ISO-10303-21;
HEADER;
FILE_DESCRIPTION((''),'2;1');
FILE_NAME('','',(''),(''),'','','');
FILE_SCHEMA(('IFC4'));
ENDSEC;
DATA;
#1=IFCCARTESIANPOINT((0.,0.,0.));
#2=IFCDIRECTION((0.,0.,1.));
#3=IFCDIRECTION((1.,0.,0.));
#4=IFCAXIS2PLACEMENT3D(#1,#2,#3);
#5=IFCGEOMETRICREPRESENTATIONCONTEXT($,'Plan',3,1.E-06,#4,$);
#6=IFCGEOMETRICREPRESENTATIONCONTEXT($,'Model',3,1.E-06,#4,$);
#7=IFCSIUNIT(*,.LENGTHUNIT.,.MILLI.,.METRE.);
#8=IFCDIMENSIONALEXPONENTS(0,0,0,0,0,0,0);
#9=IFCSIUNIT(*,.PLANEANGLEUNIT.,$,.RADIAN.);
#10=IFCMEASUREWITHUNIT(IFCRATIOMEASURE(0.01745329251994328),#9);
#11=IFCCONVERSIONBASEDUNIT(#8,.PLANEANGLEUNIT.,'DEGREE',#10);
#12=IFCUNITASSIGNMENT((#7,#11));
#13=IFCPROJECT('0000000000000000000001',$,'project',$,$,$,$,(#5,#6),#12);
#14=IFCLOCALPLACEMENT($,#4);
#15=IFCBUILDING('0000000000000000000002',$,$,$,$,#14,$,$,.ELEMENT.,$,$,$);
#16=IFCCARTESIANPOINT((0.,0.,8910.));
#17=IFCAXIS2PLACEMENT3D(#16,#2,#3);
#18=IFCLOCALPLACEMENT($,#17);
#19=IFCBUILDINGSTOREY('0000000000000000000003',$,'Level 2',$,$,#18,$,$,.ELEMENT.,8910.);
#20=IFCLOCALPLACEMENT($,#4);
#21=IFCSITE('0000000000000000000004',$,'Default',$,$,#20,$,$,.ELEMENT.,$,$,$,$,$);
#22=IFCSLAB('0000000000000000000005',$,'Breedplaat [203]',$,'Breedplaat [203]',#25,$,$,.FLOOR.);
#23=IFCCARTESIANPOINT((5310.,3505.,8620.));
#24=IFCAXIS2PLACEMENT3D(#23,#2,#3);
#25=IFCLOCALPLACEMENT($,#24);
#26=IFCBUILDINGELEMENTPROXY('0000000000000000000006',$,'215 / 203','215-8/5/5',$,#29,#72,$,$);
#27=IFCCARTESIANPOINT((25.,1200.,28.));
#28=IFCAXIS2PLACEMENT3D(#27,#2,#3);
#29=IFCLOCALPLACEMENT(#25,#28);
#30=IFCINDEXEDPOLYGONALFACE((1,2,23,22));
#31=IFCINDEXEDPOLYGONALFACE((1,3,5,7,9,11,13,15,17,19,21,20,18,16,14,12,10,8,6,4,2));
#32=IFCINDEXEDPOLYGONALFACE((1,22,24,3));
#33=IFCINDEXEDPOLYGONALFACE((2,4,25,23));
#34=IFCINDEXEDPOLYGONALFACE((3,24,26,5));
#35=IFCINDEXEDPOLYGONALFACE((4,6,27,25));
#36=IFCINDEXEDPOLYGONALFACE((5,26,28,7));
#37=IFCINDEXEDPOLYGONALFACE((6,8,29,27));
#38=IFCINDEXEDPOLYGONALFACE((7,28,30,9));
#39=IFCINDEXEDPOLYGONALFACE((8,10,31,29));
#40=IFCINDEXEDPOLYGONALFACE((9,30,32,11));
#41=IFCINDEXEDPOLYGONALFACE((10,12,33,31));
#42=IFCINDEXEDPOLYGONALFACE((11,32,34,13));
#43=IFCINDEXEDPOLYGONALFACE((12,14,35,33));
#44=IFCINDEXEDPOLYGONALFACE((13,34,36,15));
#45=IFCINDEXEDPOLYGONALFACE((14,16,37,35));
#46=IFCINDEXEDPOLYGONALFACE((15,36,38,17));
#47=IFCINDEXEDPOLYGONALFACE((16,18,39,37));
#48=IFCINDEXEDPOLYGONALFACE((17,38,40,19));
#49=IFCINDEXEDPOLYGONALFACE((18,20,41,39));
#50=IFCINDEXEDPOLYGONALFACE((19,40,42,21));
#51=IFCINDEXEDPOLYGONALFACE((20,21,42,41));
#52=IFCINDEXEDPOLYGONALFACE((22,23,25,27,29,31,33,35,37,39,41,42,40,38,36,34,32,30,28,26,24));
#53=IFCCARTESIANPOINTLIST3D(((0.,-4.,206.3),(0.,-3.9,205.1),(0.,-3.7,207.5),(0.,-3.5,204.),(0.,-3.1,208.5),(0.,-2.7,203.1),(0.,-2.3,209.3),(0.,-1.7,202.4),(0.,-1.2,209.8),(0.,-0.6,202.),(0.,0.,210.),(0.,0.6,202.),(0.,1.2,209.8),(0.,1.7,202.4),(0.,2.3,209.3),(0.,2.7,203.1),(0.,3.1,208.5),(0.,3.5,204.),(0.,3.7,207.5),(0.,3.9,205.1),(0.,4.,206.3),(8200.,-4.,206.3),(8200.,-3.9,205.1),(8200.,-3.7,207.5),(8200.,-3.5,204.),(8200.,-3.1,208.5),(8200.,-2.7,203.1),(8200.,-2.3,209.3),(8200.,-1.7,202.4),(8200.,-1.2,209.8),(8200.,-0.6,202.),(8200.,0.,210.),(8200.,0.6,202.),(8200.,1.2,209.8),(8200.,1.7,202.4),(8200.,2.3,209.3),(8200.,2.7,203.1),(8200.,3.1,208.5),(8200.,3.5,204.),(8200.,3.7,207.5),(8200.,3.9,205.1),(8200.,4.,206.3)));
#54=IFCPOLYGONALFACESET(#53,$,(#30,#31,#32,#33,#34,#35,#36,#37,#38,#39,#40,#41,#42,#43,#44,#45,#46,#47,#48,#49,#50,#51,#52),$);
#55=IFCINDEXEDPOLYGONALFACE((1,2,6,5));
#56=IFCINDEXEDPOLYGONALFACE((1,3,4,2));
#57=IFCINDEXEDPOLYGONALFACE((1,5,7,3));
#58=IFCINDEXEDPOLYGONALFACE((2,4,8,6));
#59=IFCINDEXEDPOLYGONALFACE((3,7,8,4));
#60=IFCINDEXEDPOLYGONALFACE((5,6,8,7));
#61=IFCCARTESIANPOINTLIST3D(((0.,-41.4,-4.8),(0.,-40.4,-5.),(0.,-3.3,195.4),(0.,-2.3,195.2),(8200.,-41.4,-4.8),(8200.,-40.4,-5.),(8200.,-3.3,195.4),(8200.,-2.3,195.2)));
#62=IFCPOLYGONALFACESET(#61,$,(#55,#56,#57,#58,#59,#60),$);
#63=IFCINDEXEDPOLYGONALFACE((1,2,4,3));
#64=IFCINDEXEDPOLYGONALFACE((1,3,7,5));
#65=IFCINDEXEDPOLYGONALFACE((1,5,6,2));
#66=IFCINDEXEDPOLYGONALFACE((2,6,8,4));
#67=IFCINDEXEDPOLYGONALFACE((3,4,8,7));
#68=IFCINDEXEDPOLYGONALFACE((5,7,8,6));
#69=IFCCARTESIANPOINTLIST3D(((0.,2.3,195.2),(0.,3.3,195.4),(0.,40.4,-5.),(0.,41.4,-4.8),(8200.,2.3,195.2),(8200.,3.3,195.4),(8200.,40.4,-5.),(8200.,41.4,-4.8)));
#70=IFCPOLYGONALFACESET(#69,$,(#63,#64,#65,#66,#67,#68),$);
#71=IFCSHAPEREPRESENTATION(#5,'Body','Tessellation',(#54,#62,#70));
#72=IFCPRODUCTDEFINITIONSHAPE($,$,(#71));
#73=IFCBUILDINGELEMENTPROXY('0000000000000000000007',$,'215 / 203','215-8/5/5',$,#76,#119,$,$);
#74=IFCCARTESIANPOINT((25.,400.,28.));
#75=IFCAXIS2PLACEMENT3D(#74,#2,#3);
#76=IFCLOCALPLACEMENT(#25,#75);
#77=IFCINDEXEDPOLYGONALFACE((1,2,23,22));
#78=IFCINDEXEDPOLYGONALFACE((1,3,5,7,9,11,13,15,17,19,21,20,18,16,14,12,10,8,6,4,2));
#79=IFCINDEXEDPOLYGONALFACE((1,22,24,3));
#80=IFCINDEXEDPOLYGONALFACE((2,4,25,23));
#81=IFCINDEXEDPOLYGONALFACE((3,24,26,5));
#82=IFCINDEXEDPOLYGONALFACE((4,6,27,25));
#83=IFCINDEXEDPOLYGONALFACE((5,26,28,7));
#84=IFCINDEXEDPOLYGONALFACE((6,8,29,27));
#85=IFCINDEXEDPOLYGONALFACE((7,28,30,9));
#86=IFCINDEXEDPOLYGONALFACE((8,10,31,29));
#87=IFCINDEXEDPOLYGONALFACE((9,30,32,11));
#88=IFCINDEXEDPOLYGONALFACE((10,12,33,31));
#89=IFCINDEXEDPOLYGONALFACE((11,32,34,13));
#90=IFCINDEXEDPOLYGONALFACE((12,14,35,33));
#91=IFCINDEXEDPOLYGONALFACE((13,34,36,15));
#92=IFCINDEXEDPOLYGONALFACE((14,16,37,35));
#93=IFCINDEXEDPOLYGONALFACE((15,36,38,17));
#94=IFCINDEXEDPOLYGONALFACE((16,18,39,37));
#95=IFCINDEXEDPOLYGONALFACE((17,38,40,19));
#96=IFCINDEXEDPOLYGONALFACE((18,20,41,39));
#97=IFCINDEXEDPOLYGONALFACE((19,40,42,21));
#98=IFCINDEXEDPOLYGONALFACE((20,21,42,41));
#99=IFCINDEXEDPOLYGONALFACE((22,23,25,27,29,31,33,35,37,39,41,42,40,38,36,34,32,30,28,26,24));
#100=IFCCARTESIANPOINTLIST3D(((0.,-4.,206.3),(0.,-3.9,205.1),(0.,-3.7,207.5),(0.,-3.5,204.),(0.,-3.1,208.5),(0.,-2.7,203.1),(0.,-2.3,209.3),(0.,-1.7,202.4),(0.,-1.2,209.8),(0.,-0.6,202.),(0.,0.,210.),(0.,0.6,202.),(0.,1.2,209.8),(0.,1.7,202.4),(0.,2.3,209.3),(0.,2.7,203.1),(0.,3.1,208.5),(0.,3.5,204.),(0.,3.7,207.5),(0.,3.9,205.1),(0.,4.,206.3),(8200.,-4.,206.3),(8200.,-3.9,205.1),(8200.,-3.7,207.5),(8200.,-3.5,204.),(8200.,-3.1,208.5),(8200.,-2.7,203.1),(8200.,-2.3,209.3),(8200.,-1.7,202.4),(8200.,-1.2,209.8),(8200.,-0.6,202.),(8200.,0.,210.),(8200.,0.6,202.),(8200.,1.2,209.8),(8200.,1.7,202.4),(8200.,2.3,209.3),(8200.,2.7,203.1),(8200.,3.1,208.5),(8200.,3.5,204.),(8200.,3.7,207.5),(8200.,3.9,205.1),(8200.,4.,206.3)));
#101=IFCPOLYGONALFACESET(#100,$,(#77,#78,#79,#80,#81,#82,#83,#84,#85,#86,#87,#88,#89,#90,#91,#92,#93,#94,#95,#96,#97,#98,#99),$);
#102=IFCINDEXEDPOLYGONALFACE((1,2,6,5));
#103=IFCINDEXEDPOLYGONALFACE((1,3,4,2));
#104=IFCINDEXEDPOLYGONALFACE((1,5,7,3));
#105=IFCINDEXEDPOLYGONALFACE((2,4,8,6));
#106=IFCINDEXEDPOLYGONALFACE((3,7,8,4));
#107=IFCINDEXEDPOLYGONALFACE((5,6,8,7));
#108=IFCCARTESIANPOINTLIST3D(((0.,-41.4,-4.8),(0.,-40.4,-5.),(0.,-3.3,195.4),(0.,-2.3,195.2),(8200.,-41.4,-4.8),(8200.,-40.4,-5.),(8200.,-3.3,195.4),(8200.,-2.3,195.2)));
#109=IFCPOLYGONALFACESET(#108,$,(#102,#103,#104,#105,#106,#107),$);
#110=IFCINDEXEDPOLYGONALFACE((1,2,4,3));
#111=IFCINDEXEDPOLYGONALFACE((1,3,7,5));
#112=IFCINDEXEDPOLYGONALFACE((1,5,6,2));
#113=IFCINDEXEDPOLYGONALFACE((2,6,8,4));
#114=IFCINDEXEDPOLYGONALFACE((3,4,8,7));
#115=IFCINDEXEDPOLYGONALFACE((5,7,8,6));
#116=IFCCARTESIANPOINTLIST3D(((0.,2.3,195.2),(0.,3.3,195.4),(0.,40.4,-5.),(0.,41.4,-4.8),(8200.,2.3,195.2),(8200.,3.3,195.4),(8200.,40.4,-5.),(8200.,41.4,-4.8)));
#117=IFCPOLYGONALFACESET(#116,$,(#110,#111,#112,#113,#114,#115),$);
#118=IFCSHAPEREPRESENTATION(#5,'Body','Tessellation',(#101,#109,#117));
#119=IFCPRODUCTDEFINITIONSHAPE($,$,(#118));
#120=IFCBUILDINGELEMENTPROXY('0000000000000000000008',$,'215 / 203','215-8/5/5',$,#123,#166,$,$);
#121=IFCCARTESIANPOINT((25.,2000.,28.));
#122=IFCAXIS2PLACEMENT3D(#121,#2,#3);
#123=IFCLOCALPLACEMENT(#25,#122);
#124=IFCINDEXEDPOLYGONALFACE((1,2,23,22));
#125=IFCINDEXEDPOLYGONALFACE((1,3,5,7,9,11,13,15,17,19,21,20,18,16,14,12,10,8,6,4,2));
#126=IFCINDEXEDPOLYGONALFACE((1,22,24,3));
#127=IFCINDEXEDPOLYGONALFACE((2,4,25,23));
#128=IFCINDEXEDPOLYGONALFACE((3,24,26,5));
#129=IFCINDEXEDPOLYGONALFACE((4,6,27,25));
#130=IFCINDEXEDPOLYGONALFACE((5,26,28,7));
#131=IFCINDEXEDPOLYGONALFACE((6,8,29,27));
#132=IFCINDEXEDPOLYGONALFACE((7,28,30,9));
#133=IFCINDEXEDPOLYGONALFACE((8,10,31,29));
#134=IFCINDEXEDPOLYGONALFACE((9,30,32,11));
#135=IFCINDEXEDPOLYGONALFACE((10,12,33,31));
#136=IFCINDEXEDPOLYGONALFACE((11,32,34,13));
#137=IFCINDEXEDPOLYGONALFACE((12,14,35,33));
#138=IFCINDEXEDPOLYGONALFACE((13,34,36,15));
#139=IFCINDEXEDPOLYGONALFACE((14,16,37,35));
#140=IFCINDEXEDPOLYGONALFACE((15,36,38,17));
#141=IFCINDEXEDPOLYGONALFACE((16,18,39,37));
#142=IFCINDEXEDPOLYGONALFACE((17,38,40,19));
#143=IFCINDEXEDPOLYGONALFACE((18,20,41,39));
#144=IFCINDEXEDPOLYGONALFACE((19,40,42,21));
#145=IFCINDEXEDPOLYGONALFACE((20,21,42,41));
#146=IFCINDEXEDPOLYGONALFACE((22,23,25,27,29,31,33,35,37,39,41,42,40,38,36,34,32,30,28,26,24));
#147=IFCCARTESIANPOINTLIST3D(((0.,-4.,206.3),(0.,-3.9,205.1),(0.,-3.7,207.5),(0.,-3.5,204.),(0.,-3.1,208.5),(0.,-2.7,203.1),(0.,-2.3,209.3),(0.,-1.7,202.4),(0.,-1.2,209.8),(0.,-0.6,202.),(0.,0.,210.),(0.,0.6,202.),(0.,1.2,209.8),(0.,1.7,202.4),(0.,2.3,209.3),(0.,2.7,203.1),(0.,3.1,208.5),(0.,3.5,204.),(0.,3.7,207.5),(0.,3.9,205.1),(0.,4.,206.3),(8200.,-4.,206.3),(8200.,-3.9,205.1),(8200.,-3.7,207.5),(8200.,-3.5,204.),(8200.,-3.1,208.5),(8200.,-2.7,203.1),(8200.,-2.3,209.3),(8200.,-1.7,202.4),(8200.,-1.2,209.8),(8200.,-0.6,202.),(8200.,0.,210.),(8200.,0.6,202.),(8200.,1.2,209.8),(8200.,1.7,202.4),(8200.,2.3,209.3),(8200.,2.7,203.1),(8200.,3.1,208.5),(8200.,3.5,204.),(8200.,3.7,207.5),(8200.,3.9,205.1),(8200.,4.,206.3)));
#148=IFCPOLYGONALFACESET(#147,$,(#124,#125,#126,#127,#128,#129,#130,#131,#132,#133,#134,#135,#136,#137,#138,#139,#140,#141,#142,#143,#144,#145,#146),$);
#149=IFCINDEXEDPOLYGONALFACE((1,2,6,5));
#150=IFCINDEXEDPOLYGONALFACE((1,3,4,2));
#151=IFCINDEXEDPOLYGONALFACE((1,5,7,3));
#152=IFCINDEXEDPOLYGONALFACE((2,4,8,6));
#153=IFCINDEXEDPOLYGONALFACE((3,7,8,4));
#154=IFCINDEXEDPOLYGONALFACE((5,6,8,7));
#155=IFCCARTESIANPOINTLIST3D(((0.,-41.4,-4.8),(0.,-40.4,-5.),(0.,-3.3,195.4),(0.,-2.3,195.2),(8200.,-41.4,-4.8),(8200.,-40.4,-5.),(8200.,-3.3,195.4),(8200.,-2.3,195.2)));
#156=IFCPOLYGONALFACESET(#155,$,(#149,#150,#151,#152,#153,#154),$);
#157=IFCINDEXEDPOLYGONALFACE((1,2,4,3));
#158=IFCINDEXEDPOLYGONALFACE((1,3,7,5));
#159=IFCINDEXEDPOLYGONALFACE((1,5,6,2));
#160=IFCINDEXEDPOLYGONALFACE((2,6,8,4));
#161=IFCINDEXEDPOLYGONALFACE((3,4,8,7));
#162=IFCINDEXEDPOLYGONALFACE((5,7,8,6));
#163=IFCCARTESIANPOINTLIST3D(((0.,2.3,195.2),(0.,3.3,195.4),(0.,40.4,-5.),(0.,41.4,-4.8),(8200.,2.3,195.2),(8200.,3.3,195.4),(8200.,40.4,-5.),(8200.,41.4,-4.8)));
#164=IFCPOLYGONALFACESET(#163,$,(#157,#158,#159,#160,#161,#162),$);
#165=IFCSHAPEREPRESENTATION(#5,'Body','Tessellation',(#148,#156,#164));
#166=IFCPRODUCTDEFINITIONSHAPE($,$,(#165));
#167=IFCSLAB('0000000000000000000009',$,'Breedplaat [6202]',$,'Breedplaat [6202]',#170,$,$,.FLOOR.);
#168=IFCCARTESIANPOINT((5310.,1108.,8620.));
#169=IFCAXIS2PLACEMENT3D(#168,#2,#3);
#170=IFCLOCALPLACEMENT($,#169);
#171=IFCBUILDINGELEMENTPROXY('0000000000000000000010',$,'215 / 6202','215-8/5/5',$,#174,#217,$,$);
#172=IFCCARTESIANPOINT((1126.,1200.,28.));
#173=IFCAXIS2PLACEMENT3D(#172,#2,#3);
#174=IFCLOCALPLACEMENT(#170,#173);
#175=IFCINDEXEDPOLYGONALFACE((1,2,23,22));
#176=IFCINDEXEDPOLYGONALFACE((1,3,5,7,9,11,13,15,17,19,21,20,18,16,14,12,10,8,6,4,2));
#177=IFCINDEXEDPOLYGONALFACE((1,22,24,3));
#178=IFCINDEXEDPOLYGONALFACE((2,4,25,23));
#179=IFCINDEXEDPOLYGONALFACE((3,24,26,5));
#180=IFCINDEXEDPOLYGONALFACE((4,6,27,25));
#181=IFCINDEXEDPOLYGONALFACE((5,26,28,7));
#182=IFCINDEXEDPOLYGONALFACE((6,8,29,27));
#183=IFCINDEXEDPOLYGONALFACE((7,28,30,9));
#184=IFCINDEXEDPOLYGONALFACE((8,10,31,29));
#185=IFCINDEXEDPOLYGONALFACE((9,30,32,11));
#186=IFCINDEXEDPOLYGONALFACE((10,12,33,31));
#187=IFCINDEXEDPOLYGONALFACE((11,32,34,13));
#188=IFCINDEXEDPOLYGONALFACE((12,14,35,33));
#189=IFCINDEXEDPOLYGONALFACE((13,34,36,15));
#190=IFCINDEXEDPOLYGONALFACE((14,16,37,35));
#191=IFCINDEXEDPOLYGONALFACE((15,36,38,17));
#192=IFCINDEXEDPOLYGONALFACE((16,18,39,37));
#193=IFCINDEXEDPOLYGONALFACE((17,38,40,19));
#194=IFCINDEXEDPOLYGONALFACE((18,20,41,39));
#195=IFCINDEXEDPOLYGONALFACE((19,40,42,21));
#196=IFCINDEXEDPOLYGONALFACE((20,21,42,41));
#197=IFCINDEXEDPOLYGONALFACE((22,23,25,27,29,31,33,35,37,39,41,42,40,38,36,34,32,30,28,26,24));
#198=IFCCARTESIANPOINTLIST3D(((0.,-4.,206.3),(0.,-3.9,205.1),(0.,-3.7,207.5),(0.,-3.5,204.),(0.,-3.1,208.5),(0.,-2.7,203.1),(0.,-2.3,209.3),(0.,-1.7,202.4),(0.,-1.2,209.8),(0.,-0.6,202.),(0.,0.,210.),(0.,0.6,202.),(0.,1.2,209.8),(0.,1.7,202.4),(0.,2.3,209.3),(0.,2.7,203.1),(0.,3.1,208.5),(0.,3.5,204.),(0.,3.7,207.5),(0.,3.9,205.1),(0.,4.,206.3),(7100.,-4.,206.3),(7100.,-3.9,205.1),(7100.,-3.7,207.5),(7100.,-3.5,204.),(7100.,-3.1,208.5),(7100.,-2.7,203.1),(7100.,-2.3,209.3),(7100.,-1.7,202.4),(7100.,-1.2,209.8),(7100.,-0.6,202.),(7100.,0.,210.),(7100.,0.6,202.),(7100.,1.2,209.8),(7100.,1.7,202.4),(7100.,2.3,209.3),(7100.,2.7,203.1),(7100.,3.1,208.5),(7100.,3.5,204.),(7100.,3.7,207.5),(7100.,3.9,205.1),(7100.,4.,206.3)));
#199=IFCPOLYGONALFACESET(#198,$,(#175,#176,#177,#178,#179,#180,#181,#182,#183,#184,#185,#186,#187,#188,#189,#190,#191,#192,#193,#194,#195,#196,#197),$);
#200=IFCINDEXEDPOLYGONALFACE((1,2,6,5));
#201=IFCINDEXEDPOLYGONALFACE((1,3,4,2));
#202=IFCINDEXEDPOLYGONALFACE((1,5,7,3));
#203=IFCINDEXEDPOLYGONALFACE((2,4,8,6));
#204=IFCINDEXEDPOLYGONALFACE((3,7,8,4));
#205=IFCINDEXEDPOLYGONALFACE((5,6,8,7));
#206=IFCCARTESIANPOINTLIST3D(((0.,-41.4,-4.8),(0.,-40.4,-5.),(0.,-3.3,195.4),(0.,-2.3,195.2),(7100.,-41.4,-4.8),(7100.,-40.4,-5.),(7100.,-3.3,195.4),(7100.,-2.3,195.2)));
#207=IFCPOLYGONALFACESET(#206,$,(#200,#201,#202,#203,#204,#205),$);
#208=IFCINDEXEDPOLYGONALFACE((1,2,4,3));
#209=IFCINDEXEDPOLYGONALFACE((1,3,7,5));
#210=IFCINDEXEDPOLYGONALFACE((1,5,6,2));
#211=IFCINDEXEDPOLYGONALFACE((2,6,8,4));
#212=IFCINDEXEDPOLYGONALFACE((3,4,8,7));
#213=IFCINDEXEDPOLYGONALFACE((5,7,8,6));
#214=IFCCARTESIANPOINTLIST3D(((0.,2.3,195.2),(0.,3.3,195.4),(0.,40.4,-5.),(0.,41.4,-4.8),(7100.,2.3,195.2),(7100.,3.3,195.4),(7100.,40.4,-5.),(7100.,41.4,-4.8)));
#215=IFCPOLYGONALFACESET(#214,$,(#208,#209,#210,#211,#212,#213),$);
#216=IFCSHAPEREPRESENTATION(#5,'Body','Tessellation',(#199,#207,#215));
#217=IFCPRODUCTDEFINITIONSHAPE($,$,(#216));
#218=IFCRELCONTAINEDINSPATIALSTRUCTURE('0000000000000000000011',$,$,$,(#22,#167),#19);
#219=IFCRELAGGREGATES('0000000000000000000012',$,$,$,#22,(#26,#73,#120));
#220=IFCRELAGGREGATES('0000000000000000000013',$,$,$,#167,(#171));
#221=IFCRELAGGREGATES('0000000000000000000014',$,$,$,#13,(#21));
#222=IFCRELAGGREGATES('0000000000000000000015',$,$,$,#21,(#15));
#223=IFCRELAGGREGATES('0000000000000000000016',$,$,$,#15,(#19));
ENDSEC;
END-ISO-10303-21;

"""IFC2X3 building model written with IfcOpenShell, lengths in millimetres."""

from ifc_helpers import new_model, entity, si_unit, converted_unit, frame, origin_with_axes, origin_2d_with_axis, place, context, project, spatial, rectangle, circle, extrude, element, aggregate, save


model = new_model("IFC2X3")

# Units and contexts
plan_context = context("Plan", 3, precision=1e-06, world=origin_with_axes())
model_context = context("Model", 3, precision=1e-06, world=origin_with_axes())
ifc_project = project(units=[si_unit("LENGTHUNIT", "METRE", prefix="MILLI"), converted_unit("PLANEANGLEUNIT", "DEGREE", entity("IfcRatioMeasure", 0.01745329251994328), si_unit("PLANEANGLEUNIT", "RADIAN"), dimensions=[0, 0, 0, 0, 0, 0, 0])], contexts=[plan_context, model_context])

# Site, building, storey
site_placement = place(None, origin_with_axes())
site = spatial("IfcSite", under=ifc_project, at=site_placement, Name="Default", CompositionType="ELEMENT")
building_placement = place(None, origin_with_axes())
building = spatial("IfcBuilding", under=site, at=building_placement, CompositionType="ELEMENT")
storey_placement = place(None, frame((0.0, 0.0, 8910.0), z_axis=(0.0, 0.0, 1.0), x_axis=(1.0, 0.0, 0.0)))
storey = spatial("IfcBuildingStorey", under=building, at=storey_placement, Name="Level 2", CompositionType="ELEMENT", Elevation=8910.0)

# Slab, building element proxies
slab_1_placement = place(None, frame((5310.0, 3505.0, 8620.0), z_axis=(0.0, 0.0, 1.0), x_axis=(1.0, 0.0, 0.0)))
slab_1 = element("IfcSlab", 1, at=slab_1_placement, inside=storey, Name="Breedplaat [203]", ObjectType="Breedplaat [203]", PredefinedType="FLOOR")
proxy_1_placement = place(slab_1_placement, frame((25.0, 1200.0, 28.0), z_axis=(0.0, 0.0, 1.0), x_axis=(1.0, 0.0, 0.0)))
proxy_1 = element("IfcBuildingElementProxy", 2, at=proxy_1_placement, Name="215 / 203", Description="215-8/5/5", context=plan_context, shape_type="SweptSolid", body=[
    extrude(circle(Radius=4.0, at=origin_2d_with_axis()), frame((0.0, 0.0, 206.0), z_axis=(1.0, 0.0, 0.0), x_axis=(0.0, 0.0, 1.0)), (0.0, 0.0, 1.0), 8200.0),
    extrude(rectangle(XDim=203.8, YDim=1.0, at=origin_2d_with_axis()), frame((0.0, -21.9, 95.2), z_axis=(1.0, 0.0, 0.0), x_axis=(0.0, 0.187112, 0.982339)), (0.0, 0.0, 1.0), 8200.0),
    extrude(rectangle(XDim=203.8, YDim=1.0, at=origin_2d_with_axis()), frame((0.0, 21.9, 95.2), z_axis=(1.0, 0.0, 0.0), x_axis=(0.0, -0.187112, 0.982339)), (0.0, 0.0, 1.0), 8200.0),
])
proxy_2_placement = place(slab_1_placement, frame((25.0, 400.0, 28.0), z_axis=(0.0, 0.0, 1.0), x_axis=(1.0, 0.0, 0.0)))
proxy_2 = element("IfcBuildingElementProxy", 3, at=proxy_2_placement, Name="215 / 203", Description="215-8/5/5", context=plan_context, shape_type="SweptSolid", body=[
    extrude(circle(Radius=4.0, at=origin_2d_with_axis()), frame((0.0, 0.0, 206.0), z_axis=(1.0, 0.0, 0.0), x_axis=(0.0, 0.0, 1.0)), (0.0, 0.0, 1.0), 8200.0),
    extrude(rectangle(XDim=203.8, YDim=1.0, at=origin_2d_with_axis()), frame((0.0, -21.9, 95.2), z_axis=(1.0, 0.0, 0.0), x_axis=(0.0, 0.187112, 0.982339)), (0.0, 0.0, 1.0), 8200.0),
    extrude(rectangle(XDim=203.8, YDim=1.0, at=origin_2d_with_axis()), frame((0.0, 21.9, 95.2), z_axis=(1.0, 0.0, 0.0), x_axis=(0.0, -0.187112, 0.982339)), (0.0, 0.0, 1.0), 8200.0),
])
proxy_3_placement = place(slab_1_placement, frame((25.0, 2000.0, 28.0), z_axis=(0.0, 0.0, 1.0), x_axis=(1.0, 0.0, 0.0)))
proxy_3 = element("IfcBuildingElementProxy", 4, at=proxy_3_placement, Name="215 / 203", Description="215-8/5/5", context=plan_context, shape_type="SweptSolid", body=[
    extrude(circle(Radius=4.0, at=origin_2d_with_axis()), frame((0.0, 0.0, 206.0), z_axis=(1.0, 0.0, 0.0), x_axis=(0.0, 0.0, 1.0)), (0.0, 0.0, 1.0), 8200.0),
    extrude(rectangle(XDim=203.8, YDim=1.0, at=origin_2d_with_axis()), frame((0.0, -21.9, 95.2), z_axis=(1.0, 0.0, 0.0), x_axis=(0.0, 0.187112, 0.982339)), (0.0, 0.0, 1.0), 8200.0),
    extrude(rectangle(XDim=203.8, YDim=1.0, at=origin_2d_with_axis()), frame((0.0, 21.9, 95.2), z_axis=(1.0, 0.0, 0.0), x_axis=(0.0, -0.187112, 0.982339)), (0.0, 0.0, 1.0), 8200.0),
])
aggregate(slab_1, [proxy_1, proxy_2, proxy_3])

# Slab, building element proxy
slab_2_placement = place(None, frame((5310.0, 1108.0, 8620.0), z_axis=(0.0, 0.0, 1.0), x_axis=(1.0, 0.0, 0.0)))
slab_2 = element("IfcSlab", 5, at=slab_2_placement, inside=storey, Name="Breedplaat [6202]", ObjectType="Breedplaat [6202]", PredefinedType="FLOOR")
proxy_4_placement = place(slab_2_placement, frame((1126.0, 1200.0, 28.0), z_axis=(0.0, 0.0, 1.0), x_axis=(1.0, 0.0, 0.0)))
proxy_4 = element("IfcBuildingElementProxy", 6, at=proxy_4_placement, Name="215 / 6202", Description="215-8/5/5", context=plan_context, shape_type="SweptSolid", body=[
    extrude(circle(Radius=4.0, at=origin_2d_with_axis()), frame((0.0, 0.0, 206.0), z_axis=(1.0, 0.0, 0.0), x_axis=(0.0, 0.0, 1.0)), (0.0, 0.0, 1.0), 7100.0),
    extrude(rectangle(XDim=203.8, YDim=1.0, at=origin_2d_with_axis()), frame((0.0, -21.9, 95.2), z_axis=(1.0, 0.0, 0.0), x_axis=(0.0, 0.187112, 0.982339)), (0.0, 0.0, 1.0), 7100.0),
    extrude(rectangle(XDim=203.8, YDim=1.0, at=origin_2d_with_axis()), frame((0.0, 21.9, 95.2), z_axis=(1.0, 0.0, 0.0), x_axis=(0.0, -0.187112, 0.982339)), (0.0, 0.0, 1.0), 7100.0),
])
aggregate(slab_2, [proxy_4])

save(model, "model.ifc")
